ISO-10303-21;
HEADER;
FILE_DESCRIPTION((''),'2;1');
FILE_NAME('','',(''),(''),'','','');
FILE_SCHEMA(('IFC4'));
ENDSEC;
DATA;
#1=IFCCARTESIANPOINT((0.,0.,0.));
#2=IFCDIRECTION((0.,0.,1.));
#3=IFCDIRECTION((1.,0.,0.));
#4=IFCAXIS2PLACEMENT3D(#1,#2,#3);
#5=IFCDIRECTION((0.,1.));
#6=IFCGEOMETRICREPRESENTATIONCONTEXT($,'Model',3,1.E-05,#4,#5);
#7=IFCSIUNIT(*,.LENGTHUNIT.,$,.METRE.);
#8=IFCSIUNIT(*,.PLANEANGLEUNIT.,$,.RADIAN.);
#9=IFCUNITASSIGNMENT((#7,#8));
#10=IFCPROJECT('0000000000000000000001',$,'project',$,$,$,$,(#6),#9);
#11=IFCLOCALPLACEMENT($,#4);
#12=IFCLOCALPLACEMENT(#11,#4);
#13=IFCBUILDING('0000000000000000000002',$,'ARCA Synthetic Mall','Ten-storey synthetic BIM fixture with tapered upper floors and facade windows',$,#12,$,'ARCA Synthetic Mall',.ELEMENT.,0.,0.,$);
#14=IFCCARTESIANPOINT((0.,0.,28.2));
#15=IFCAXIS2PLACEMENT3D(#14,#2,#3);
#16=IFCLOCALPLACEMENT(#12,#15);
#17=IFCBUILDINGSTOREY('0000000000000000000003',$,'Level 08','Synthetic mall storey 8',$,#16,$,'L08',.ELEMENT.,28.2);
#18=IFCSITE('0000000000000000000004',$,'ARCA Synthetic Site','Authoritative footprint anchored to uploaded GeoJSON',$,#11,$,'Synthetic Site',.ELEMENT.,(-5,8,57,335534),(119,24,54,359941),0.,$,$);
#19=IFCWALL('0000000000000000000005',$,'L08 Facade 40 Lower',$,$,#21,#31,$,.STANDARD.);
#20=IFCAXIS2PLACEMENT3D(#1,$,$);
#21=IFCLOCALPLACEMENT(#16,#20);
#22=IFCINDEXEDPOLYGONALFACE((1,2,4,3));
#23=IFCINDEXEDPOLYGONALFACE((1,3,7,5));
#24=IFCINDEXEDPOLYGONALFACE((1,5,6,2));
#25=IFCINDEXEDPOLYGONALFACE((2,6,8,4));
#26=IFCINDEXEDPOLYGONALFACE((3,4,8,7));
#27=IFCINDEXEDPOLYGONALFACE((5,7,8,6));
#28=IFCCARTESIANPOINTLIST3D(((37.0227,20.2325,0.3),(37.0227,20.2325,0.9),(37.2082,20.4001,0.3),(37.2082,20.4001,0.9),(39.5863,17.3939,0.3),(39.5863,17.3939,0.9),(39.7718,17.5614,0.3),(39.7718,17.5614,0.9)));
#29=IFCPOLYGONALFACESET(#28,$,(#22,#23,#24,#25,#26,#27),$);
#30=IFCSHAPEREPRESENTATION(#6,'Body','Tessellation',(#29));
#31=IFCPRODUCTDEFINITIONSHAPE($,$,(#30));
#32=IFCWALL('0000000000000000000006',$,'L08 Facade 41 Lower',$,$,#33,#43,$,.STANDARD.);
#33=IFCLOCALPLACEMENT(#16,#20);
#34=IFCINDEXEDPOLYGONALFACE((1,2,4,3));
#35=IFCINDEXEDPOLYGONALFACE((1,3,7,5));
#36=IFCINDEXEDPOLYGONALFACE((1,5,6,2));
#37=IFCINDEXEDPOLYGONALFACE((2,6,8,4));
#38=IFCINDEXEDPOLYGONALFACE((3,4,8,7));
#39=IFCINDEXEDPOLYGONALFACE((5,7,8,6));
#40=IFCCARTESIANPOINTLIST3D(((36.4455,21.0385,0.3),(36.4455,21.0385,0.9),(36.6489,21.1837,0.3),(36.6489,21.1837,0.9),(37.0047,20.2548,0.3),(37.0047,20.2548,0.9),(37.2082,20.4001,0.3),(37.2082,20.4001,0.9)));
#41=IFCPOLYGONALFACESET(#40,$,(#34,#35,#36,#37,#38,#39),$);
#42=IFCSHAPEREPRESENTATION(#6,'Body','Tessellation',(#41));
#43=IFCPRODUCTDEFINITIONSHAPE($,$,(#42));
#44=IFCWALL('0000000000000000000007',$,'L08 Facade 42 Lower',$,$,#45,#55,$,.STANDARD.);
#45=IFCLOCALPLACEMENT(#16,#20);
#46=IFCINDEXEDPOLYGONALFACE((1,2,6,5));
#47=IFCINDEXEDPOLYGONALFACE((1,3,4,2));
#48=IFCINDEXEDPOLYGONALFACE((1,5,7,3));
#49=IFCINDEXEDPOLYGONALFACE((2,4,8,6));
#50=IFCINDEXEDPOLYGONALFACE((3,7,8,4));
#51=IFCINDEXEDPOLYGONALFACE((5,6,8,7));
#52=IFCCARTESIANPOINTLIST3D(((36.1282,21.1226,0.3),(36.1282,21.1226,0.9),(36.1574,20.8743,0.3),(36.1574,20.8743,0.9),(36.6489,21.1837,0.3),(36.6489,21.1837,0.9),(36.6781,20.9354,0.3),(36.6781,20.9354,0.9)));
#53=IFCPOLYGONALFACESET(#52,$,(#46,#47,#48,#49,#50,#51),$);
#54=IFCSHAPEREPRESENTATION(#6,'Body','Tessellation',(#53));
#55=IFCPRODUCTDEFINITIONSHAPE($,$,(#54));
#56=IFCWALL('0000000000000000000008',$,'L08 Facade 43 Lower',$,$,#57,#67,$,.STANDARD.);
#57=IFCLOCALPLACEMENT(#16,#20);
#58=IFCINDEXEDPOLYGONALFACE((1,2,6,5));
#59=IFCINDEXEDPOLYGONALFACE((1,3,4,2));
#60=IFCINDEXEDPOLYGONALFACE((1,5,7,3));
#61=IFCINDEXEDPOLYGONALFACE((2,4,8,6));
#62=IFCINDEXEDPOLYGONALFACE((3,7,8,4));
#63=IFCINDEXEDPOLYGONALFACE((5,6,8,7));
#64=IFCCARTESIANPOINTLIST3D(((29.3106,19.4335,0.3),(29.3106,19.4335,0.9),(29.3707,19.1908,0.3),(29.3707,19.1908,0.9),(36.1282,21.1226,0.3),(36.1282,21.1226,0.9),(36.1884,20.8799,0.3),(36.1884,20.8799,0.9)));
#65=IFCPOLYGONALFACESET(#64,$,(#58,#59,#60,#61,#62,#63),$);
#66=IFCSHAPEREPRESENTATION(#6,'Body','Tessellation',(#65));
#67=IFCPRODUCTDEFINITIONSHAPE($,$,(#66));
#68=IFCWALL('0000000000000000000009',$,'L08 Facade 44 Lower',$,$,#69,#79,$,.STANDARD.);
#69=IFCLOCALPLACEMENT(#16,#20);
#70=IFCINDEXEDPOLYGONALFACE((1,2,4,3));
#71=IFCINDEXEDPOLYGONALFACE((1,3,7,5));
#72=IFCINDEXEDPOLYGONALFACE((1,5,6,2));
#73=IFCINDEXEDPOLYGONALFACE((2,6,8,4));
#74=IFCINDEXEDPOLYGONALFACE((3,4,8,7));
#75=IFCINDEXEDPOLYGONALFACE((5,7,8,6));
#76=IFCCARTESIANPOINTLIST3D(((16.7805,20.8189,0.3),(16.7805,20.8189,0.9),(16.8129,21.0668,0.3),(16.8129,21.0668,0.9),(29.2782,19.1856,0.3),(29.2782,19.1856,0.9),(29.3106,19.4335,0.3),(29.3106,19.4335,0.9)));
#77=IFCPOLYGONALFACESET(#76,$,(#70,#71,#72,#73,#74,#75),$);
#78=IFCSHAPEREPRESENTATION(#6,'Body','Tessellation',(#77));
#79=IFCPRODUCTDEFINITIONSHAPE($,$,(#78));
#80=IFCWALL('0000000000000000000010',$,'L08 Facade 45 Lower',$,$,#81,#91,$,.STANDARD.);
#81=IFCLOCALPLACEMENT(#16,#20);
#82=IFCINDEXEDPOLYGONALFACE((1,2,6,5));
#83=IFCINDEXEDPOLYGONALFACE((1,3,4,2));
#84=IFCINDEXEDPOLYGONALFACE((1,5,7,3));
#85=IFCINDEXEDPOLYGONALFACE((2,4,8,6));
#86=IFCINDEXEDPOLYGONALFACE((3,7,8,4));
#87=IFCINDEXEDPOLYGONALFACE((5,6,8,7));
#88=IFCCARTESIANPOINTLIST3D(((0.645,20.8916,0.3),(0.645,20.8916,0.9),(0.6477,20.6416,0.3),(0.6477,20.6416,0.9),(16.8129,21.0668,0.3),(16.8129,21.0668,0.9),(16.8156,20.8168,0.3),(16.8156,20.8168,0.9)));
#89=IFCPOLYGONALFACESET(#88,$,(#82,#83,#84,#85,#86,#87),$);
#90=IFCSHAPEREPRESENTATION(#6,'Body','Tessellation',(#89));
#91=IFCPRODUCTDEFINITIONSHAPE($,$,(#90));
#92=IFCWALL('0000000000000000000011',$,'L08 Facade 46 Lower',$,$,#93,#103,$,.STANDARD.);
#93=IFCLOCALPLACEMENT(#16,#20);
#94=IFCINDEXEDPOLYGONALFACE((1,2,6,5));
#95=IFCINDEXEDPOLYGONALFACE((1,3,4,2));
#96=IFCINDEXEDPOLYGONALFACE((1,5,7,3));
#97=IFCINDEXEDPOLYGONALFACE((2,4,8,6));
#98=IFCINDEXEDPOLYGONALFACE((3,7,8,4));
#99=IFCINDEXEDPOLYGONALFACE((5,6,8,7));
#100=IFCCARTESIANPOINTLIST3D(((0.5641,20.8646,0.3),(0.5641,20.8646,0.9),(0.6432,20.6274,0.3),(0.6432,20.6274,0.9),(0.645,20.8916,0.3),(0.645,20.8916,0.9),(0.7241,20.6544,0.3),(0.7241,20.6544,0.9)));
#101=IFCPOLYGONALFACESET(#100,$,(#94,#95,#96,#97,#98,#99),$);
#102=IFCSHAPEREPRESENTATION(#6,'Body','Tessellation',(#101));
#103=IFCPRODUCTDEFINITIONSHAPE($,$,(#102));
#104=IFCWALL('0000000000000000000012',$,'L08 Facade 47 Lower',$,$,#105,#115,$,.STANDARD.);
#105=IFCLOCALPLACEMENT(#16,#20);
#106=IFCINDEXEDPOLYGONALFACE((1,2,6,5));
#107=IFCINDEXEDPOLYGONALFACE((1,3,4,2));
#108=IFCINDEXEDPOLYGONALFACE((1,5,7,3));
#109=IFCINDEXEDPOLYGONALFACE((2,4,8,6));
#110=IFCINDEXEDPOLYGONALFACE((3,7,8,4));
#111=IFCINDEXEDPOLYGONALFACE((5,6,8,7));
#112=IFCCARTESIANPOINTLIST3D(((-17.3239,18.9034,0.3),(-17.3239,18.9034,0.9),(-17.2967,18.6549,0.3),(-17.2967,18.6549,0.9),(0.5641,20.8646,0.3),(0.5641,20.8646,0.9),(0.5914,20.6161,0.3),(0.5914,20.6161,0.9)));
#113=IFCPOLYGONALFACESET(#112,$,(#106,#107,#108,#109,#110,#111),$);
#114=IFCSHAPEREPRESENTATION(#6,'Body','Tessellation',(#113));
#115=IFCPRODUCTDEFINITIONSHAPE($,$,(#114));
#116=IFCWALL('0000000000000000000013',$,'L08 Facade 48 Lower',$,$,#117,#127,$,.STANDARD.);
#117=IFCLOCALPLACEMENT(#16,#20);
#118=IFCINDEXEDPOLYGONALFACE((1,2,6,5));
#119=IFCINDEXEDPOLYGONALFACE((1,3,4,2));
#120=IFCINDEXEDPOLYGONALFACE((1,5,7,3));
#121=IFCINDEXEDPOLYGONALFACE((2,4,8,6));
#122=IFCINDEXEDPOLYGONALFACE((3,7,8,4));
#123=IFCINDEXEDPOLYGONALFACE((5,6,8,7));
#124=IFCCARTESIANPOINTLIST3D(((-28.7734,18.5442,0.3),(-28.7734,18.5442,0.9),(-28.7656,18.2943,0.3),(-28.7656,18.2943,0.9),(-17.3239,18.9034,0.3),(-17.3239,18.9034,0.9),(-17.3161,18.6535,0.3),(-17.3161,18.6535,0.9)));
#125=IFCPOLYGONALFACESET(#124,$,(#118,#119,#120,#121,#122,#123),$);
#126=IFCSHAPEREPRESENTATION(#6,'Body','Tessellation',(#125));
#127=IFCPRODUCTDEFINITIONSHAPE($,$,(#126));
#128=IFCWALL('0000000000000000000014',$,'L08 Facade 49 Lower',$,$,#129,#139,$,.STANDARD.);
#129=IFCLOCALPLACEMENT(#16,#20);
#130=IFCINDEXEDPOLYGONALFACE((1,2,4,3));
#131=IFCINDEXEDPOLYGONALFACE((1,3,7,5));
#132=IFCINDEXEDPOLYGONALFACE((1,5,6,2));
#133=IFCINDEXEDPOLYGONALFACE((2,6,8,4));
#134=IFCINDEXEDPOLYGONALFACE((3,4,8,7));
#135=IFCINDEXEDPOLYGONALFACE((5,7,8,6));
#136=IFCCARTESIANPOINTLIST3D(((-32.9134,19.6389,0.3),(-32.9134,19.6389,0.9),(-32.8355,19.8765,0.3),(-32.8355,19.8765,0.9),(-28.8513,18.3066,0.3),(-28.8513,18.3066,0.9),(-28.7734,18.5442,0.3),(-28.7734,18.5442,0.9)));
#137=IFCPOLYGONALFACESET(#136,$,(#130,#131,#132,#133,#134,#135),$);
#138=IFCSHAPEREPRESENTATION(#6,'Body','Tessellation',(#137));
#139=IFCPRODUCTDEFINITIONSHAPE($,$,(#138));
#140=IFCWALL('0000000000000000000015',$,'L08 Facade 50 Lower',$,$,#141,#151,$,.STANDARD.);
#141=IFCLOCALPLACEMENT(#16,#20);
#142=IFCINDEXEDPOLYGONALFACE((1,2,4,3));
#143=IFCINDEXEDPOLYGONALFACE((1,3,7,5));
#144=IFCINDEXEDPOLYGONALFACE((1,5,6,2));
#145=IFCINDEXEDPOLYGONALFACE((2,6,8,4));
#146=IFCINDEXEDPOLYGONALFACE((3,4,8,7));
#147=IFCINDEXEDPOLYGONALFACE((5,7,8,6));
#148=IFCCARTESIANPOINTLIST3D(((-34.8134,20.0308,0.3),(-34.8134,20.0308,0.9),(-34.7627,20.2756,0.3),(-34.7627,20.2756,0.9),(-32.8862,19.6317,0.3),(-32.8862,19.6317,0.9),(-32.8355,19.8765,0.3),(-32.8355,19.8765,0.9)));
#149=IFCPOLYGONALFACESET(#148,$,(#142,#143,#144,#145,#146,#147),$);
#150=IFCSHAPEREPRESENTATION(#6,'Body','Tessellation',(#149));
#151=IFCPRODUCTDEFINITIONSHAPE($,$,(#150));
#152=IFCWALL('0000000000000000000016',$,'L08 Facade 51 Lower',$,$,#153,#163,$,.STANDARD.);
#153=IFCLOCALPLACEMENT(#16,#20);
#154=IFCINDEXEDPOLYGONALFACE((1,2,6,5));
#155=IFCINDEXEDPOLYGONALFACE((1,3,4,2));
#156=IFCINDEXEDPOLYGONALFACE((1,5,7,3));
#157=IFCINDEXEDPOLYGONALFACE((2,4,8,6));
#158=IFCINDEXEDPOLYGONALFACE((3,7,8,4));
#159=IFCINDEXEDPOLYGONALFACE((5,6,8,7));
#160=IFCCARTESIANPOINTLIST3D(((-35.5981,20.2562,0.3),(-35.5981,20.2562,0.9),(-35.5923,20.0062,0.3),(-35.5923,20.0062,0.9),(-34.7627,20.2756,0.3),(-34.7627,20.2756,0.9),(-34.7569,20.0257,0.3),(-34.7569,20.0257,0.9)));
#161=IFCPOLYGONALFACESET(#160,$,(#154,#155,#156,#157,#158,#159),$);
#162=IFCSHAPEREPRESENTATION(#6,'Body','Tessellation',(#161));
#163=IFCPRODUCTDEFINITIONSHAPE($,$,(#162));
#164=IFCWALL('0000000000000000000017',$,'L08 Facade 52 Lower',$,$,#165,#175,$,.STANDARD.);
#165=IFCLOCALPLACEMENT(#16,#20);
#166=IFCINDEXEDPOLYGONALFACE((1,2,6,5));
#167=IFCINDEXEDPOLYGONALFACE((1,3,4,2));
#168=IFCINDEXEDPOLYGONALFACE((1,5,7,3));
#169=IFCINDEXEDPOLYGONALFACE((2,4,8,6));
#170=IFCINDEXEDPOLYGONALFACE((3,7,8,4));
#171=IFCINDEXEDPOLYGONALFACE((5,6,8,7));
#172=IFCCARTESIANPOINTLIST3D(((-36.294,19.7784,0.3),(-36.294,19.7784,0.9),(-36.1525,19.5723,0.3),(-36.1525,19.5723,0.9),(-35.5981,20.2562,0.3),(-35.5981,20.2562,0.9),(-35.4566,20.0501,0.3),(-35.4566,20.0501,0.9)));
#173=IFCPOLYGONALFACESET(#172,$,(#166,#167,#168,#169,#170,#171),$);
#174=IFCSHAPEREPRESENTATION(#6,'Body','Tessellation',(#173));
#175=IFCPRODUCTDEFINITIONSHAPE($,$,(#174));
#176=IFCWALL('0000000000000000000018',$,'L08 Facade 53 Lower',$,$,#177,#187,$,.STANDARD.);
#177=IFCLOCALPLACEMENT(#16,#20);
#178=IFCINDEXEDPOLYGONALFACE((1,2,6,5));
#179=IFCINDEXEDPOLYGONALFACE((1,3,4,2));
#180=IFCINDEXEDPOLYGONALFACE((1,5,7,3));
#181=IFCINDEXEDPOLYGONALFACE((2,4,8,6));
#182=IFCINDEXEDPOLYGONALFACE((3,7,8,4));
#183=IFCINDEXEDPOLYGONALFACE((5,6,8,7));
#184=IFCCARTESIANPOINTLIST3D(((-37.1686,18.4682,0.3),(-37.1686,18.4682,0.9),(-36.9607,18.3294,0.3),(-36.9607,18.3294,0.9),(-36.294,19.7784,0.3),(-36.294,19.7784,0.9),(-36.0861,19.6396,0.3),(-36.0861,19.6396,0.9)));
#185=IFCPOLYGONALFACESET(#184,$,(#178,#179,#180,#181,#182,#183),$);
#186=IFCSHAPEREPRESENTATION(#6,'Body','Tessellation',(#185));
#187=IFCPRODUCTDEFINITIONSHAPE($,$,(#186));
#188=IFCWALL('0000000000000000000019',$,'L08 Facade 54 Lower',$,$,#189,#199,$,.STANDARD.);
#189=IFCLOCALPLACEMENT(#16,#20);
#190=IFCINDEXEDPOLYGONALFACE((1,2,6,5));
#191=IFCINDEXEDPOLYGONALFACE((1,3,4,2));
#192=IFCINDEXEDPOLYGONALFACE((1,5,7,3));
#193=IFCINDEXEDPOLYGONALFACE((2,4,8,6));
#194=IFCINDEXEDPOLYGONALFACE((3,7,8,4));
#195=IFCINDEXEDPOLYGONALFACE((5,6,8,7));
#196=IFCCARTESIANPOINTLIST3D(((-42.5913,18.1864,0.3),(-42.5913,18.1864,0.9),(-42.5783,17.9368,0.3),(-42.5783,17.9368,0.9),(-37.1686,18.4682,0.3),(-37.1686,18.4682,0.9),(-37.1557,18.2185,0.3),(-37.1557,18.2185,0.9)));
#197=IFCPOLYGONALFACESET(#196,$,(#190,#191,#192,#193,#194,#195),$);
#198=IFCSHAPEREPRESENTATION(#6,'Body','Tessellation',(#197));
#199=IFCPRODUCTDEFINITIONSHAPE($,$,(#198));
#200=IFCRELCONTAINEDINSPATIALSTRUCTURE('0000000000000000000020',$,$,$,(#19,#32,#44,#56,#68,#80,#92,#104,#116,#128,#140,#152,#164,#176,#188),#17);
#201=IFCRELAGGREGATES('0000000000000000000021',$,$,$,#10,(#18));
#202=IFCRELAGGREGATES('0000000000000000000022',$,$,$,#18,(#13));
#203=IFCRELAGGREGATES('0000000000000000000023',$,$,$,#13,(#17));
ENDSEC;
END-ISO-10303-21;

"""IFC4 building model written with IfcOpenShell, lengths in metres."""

from ifc_helpers import new_model, si_unit, direction, frame, origin_with_axes, place, context, project, spatial, polyline, outline, extrude, element, save


model = new_model("IFC4")

# Units and contexts
model_context = context("Model", 3, precision=1e-05, world=origin_with_axes(), true_north=direction((0.0, 1.0)))
ifc_project = project(units=[si_unit("LENGTHUNIT", "METRE"), si_unit("PLANEANGLEUNIT", "RADIAN")], contexts=[model_context])

# Site, building, storey
site_placement = place(None, origin_with_axes())
site = spatial("IfcSite", under=ifc_project, at=site_placement, Name="ARCA Synthetic Site", Description="Authoritative footprint anchored to uploaded GeoJSON", LongName="Synthetic Site", CompositionType="ELEMENT", RefLatitude=(-5, 8, 57, 335534), RefLongitude=(119, 24, 54, 359941), RefElevation=0.0)
building_placement = place(site_placement, origin_with_axes())
building = spatial("IfcBuilding", under=site, at=building_placement, Name="ARCA Synthetic Mall", Description="Ten-storey synthetic BIM fixture with tapered upper floors and facade windows", LongName="ARCA Synthetic Mall", CompositionType="ELEMENT", ElevationOfRefHeight=0.0, ElevationOfTerrain=0.0)
storey_placement = place(building_placement, frame((0.0, 0.0, 28.2), z_axis=(0.0, 0.0, 1.0), x_axis=(1.0, 0.0, 0.0)))
storey = spatial("IfcBuildingStorey", under=building, at=storey_placement, Name="Level 08", Description="Synthetic mall storey 8", LongName="L08", CompositionType="ELEMENT", Elevation=28.2)

# Walls
wall_1_placement = place(storey_placement, frame((0.0, 0.0, 0.3), z_axis=(0.0, 0.0, 1.0), x_axis=(1.0, 0.0, 0.0)))
element("IfcWall", 1, at=wall_1_placement, inside=storey, Name="L08 Facade 40 Lower", PredefinedType="STANDARD", context=model_context, shape_type="SweptSolid", body=[
    extrude(outline(polyline([(39.7718, 17.5614), (37.2082, 20.4001), (37.0227, 20.2325), (39.5863, 17.3939), (39.7718, 17.5614)])), origin_with_axes(), (0.0, 0.0, 1.0), 0.6),
])
wall_2_placement = place(storey_placement, frame((0.0, 0.0, 0.3), z_axis=(0.0, 0.0, 1.0), x_axis=(1.0, 0.0, 0.0)))
element("IfcWall", 2, at=wall_2_placement, inside=storey, Name="L08 Facade 41 Lower", PredefinedType="STANDARD", context=model_context, shape_type="SweptSolid", body=[
    extrude(outline(polyline([(37.2082, 20.4001), (36.6489, 21.1837), (36.4455, 21.0385), (37.0047, 20.2548), (37.2082, 20.4001)])), origin_with_axes(), (0.0, 0.0, 1.0), 0.6),
])
wall_3_placement = place(storey_placement, frame((0.0, 0.0, 0.3), z_axis=(0.0, 0.0, 1.0), x_axis=(1.0, 0.0, 0.0)))
element("IfcWall", 3, at=wall_3_placement, inside=storey, Name="L08 Facade 42 Lower", PredefinedType="STANDARD", context=model_context, shape_type="SweptSolid", body=[
    extrude(outline(polyline([(36.6489, 21.1837), (36.1283, 21.1226), (36.1574, 20.8743), (36.6781, 20.9354), (36.6489, 21.1837)])), origin_with_axes(), (0.0, 0.0, 1.0), 0.6),
])
wall_4_placement = place(storey_placement, frame((0.0, 0.0, 0.3), z_axis=(0.0, 0.0, 1.0), x_axis=(1.0, 0.0, 0.0)))
element("IfcWall", 4, at=wall_4_placement, inside=storey, Name="L08 Facade 43 Lower", PredefinedType="STANDARD", context=model_context, shape_type="SweptSolid", body=[
    extrude(outline(polyline([(36.1283, 21.1226), (29.3105, 19.4335), (29.3707, 19.1908), (36.1884, 20.8799), (36.1283, 21.1226)])), origin_with_axes(), (0.0, 0.0, 1.0), 0.6),
])
wall_5_placement = place(storey_placement, frame((0.0, 0.0, 0.3), z_axis=(0.0, 0.0, 1.0), x_axis=(1.0, 0.0, 0.0)))
element("IfcWall", 5, at=wall_5_placement, inside=storey, Name="L08 Facade 44 Lower", PredefinedType="STANDARD", context=model_context, shape_type="SweptSolid", body=[
    extrude(outline(polyline([(29.3105, 19.4335), (16.8129, 21.0668), (16.7805, 20.8189), (29.2782, 19.1856), (29.3105, 19.4335)])), origin_with_axes(), (0.0, 0.0, 1.0), 0.6),
])
wall_6_placement = place(storey_placement, frame((0.0, 0.0, 0.3), z_axis=(0.0, 0.0, 1.0), x_axis=(1.0, 0.0, 0.0)))
element("IfcWall", 6, at=wall_6_placement, inside=storey, Name="L08 Facade 45 Lower", PredefinedType="STANDARD", context=model_context, shape_type="SweptSolid", body=[
    extrude(outline(polyline([(16.8129, 21.0668), (0.645, 20.8916), (0.6477, 20.6416), (16.8156, 20.8168), (16.8129, 21.0668)])), origin_with_axes(), (0.0, 0.0, 1.0), 0.6),
])
wall_7_placement = place(storey_placement, frame((0.0, 0.0, 0.3), z_axis=(0.0, 0.0, 1.0), x_axis=(1.0, 0.0, 0.0)))
element("IfcWall", 7, at=wall_7_placement, inside=storey, Name="L08 Facade 46 Lower", PredefinedType="STANDARD", context=model_context, shape_type="SweptSolid", body=[
    extrude(outline(polyline([(0.645, 20.8916), (0.5641, 20.8646), (0.6432, 20.6274), (0.7241, 20.6544), (0.645, 20.8916)])), origin_with_axes(), (0.0, 0.0, 1.0), 0.6),
])
wall_8_placement = place(storey_placement, frame((0.0, 0.0, 0.3), z_axis=(0.0, 0.0, 1.0), x_axis=(1.0, 0.0, 0.0)))
element("IfcWall", 8, at=wall_8_placement, inside=storey, Name="L08 Facade 47 Lower", PredefinedType="STANDARD", context=model_context, shape_type="SweptSolid", body=[
    extrude(outline(polyline([(0.5641, 20.8646), (-17.3239, 18.9034), (-17.2967, 18.6549), (0.5914, 20.6161), (0.5641, 20.8646)])), origin_with_axes(), (0.0, 0.0, 1.0), 0.6),
])
wall_9_placement = place(storey_placement, frame((0.0, 0.0, 0.3), z_axis=(0.0, 0.0, 1.0), x_axis=(1.0, 0.0, 0.0)))
element("IfcWall", 9, at=wall_9_placement, inside=storey, Name="L08 Facade 48 Lower", PredefinedType="STANDARD", context=model_context, shape_type="SweptSolid", body=[
    extrude(outline(polyline([(-17.3239, 18.9034), (-28.7734, 18.5442), (-28.7656, 18.2943), (-17.3161, 18.6535), (-17.3239, 18.9034)])), origin_with_axes(), (0.0, 0.0, 1.0), 0.6),
])
wall_10_placement = place(storey_placement, frame((0.0, 0.0, 0.3), z_axis=(0.0, 0.0, 1.0), x_axis=(1.0, 0.0, 0.0)))
element("IfcWall", 10, at=wall_10_placement, inside=storey, Name="L08 Facade 49 Lower", PredefinedType="STANDARD", context=model_context, shape_type="SweptSolid", body=[
    extrude(outline(polyline([(-28.7734, 18.5442), (-32.8355, 19.8765), (-32.9134, 19.6389), (-28.8513, 18.3066), (-28.7734, 18.5442)])), origin_with_axes(), (0.0, 0.0, 1.0), 0.6),
])
wall_11_placement = place(storey_placement, frame((0.0, 0.0, 0.3), z_axis=(0.0, 0.0, 1.0), x_axis=(1.0, 0.0, 0.0)))
element("IfcWall", 11, at=wall_11_placement, inside=storey, Name="L08 Facade 50 Lower", PredefinedType="STANDARD", context=model_context, shape_type="SweptSolid", body=[
    extrude(outline(polyline([(-32.8355, 19.8765), (-34.7627, 20.2756), (-34.8134, 20.0308), (-32.8862, 19.6317), (-32.8355, 19.8765)])), origin_with_axes(), (0.0, 0.0, 1.0), 0.6),
])
wall_12_placement = place(storey_placement, frame((0.0, 0.0, 0.3), z_axis=(0.0, 0.0, 1.0), x_axis=(1.0, 0.0, 0.0)))
element("IfcWall", 12, at=wall_12_placement, inside=storey, Name="L08 Facade 51 Lower", PredefinedType="STANDARD", context=model_context, shape_type="SweptSolid", body=[
    extrude(outline(polyline([(-34.7627, 20.2756), (-35.5981, 20.2562), (-35.5923, 20.0062), (-34.7569, 20.0257), (-34.7627, 20.2756)])), origin_with_axes(), (0.0, 0.0, 1.0), 0.6),
])
wall_13_placement = place(storey_placement, frame((0.0, 0.0, 0.3), z_axis=(0.0, 0.0, 1.0), x_axis=(1.0, 0.0, 0.0)))
element("IfcWall", 13, at=wall_13_placement, inside=storey, Name="L08 Facade 52 Lower", PredefinedType="STANDARD", context=model_context, shape_type="SweptSolid", body=[
    extrude(outline(polyline([(-35.5981, 20.2562), (-36.294, 19.7784), (-36.1525, 19.5723), (-35.4566, 20.0501), (-35.5981, 20.2562)])), origin_with_axes(), (0.0, 0.0, 1.0), 0.6),
])
wall_14_placement = place(storey_placement, frame((0.0, 0.0, 0.3), z_axis=(0.0, 0.0, 1.0), x_axis=(1.0, 0.0, 0.0)))
element("IfcWall", 14, at=wall_14_placement, inside=storey, Name="L08 Facade 53 Lower", PredefinedType="STANDARD", context=model_context, shape_type="SweptSolid", body=[
    extrude(outline(polyline([(-36.294, 19.7784), (-37.1686, 18.4682), (-36.9607, 18.3294), (-36.0861, 19.6396), (-36.294, 19.7784)])), origin_with_axes(), (0.0, 0.0, 1.0), 0.6),
])
wall_15_placement = place(storey_placement, frame((0.0, 0.0, 0.3), z_axis=(0.0, 0.0, 1.0), x_axis=(1.0, 0.0, 0.0)))
element("IfcWall", 15, at=wall_15_placement, inside=storey, Name="L08 Facade 54 Lower", PredefinedType="STANDARD", context=model_context, shape_type="SweptSolid", body=[
    extrude(outline(polyline([(-37.1686, 18.4682), (-42.5913, 18.1864), (-42.5783, 17.9368), (-37.1557, 18.2185), (-37.1686, 18.4682)])), origin_with_axes(), (0.0, 0.0, 1.0), 0.6),
])

save(model, "model.ifc")
